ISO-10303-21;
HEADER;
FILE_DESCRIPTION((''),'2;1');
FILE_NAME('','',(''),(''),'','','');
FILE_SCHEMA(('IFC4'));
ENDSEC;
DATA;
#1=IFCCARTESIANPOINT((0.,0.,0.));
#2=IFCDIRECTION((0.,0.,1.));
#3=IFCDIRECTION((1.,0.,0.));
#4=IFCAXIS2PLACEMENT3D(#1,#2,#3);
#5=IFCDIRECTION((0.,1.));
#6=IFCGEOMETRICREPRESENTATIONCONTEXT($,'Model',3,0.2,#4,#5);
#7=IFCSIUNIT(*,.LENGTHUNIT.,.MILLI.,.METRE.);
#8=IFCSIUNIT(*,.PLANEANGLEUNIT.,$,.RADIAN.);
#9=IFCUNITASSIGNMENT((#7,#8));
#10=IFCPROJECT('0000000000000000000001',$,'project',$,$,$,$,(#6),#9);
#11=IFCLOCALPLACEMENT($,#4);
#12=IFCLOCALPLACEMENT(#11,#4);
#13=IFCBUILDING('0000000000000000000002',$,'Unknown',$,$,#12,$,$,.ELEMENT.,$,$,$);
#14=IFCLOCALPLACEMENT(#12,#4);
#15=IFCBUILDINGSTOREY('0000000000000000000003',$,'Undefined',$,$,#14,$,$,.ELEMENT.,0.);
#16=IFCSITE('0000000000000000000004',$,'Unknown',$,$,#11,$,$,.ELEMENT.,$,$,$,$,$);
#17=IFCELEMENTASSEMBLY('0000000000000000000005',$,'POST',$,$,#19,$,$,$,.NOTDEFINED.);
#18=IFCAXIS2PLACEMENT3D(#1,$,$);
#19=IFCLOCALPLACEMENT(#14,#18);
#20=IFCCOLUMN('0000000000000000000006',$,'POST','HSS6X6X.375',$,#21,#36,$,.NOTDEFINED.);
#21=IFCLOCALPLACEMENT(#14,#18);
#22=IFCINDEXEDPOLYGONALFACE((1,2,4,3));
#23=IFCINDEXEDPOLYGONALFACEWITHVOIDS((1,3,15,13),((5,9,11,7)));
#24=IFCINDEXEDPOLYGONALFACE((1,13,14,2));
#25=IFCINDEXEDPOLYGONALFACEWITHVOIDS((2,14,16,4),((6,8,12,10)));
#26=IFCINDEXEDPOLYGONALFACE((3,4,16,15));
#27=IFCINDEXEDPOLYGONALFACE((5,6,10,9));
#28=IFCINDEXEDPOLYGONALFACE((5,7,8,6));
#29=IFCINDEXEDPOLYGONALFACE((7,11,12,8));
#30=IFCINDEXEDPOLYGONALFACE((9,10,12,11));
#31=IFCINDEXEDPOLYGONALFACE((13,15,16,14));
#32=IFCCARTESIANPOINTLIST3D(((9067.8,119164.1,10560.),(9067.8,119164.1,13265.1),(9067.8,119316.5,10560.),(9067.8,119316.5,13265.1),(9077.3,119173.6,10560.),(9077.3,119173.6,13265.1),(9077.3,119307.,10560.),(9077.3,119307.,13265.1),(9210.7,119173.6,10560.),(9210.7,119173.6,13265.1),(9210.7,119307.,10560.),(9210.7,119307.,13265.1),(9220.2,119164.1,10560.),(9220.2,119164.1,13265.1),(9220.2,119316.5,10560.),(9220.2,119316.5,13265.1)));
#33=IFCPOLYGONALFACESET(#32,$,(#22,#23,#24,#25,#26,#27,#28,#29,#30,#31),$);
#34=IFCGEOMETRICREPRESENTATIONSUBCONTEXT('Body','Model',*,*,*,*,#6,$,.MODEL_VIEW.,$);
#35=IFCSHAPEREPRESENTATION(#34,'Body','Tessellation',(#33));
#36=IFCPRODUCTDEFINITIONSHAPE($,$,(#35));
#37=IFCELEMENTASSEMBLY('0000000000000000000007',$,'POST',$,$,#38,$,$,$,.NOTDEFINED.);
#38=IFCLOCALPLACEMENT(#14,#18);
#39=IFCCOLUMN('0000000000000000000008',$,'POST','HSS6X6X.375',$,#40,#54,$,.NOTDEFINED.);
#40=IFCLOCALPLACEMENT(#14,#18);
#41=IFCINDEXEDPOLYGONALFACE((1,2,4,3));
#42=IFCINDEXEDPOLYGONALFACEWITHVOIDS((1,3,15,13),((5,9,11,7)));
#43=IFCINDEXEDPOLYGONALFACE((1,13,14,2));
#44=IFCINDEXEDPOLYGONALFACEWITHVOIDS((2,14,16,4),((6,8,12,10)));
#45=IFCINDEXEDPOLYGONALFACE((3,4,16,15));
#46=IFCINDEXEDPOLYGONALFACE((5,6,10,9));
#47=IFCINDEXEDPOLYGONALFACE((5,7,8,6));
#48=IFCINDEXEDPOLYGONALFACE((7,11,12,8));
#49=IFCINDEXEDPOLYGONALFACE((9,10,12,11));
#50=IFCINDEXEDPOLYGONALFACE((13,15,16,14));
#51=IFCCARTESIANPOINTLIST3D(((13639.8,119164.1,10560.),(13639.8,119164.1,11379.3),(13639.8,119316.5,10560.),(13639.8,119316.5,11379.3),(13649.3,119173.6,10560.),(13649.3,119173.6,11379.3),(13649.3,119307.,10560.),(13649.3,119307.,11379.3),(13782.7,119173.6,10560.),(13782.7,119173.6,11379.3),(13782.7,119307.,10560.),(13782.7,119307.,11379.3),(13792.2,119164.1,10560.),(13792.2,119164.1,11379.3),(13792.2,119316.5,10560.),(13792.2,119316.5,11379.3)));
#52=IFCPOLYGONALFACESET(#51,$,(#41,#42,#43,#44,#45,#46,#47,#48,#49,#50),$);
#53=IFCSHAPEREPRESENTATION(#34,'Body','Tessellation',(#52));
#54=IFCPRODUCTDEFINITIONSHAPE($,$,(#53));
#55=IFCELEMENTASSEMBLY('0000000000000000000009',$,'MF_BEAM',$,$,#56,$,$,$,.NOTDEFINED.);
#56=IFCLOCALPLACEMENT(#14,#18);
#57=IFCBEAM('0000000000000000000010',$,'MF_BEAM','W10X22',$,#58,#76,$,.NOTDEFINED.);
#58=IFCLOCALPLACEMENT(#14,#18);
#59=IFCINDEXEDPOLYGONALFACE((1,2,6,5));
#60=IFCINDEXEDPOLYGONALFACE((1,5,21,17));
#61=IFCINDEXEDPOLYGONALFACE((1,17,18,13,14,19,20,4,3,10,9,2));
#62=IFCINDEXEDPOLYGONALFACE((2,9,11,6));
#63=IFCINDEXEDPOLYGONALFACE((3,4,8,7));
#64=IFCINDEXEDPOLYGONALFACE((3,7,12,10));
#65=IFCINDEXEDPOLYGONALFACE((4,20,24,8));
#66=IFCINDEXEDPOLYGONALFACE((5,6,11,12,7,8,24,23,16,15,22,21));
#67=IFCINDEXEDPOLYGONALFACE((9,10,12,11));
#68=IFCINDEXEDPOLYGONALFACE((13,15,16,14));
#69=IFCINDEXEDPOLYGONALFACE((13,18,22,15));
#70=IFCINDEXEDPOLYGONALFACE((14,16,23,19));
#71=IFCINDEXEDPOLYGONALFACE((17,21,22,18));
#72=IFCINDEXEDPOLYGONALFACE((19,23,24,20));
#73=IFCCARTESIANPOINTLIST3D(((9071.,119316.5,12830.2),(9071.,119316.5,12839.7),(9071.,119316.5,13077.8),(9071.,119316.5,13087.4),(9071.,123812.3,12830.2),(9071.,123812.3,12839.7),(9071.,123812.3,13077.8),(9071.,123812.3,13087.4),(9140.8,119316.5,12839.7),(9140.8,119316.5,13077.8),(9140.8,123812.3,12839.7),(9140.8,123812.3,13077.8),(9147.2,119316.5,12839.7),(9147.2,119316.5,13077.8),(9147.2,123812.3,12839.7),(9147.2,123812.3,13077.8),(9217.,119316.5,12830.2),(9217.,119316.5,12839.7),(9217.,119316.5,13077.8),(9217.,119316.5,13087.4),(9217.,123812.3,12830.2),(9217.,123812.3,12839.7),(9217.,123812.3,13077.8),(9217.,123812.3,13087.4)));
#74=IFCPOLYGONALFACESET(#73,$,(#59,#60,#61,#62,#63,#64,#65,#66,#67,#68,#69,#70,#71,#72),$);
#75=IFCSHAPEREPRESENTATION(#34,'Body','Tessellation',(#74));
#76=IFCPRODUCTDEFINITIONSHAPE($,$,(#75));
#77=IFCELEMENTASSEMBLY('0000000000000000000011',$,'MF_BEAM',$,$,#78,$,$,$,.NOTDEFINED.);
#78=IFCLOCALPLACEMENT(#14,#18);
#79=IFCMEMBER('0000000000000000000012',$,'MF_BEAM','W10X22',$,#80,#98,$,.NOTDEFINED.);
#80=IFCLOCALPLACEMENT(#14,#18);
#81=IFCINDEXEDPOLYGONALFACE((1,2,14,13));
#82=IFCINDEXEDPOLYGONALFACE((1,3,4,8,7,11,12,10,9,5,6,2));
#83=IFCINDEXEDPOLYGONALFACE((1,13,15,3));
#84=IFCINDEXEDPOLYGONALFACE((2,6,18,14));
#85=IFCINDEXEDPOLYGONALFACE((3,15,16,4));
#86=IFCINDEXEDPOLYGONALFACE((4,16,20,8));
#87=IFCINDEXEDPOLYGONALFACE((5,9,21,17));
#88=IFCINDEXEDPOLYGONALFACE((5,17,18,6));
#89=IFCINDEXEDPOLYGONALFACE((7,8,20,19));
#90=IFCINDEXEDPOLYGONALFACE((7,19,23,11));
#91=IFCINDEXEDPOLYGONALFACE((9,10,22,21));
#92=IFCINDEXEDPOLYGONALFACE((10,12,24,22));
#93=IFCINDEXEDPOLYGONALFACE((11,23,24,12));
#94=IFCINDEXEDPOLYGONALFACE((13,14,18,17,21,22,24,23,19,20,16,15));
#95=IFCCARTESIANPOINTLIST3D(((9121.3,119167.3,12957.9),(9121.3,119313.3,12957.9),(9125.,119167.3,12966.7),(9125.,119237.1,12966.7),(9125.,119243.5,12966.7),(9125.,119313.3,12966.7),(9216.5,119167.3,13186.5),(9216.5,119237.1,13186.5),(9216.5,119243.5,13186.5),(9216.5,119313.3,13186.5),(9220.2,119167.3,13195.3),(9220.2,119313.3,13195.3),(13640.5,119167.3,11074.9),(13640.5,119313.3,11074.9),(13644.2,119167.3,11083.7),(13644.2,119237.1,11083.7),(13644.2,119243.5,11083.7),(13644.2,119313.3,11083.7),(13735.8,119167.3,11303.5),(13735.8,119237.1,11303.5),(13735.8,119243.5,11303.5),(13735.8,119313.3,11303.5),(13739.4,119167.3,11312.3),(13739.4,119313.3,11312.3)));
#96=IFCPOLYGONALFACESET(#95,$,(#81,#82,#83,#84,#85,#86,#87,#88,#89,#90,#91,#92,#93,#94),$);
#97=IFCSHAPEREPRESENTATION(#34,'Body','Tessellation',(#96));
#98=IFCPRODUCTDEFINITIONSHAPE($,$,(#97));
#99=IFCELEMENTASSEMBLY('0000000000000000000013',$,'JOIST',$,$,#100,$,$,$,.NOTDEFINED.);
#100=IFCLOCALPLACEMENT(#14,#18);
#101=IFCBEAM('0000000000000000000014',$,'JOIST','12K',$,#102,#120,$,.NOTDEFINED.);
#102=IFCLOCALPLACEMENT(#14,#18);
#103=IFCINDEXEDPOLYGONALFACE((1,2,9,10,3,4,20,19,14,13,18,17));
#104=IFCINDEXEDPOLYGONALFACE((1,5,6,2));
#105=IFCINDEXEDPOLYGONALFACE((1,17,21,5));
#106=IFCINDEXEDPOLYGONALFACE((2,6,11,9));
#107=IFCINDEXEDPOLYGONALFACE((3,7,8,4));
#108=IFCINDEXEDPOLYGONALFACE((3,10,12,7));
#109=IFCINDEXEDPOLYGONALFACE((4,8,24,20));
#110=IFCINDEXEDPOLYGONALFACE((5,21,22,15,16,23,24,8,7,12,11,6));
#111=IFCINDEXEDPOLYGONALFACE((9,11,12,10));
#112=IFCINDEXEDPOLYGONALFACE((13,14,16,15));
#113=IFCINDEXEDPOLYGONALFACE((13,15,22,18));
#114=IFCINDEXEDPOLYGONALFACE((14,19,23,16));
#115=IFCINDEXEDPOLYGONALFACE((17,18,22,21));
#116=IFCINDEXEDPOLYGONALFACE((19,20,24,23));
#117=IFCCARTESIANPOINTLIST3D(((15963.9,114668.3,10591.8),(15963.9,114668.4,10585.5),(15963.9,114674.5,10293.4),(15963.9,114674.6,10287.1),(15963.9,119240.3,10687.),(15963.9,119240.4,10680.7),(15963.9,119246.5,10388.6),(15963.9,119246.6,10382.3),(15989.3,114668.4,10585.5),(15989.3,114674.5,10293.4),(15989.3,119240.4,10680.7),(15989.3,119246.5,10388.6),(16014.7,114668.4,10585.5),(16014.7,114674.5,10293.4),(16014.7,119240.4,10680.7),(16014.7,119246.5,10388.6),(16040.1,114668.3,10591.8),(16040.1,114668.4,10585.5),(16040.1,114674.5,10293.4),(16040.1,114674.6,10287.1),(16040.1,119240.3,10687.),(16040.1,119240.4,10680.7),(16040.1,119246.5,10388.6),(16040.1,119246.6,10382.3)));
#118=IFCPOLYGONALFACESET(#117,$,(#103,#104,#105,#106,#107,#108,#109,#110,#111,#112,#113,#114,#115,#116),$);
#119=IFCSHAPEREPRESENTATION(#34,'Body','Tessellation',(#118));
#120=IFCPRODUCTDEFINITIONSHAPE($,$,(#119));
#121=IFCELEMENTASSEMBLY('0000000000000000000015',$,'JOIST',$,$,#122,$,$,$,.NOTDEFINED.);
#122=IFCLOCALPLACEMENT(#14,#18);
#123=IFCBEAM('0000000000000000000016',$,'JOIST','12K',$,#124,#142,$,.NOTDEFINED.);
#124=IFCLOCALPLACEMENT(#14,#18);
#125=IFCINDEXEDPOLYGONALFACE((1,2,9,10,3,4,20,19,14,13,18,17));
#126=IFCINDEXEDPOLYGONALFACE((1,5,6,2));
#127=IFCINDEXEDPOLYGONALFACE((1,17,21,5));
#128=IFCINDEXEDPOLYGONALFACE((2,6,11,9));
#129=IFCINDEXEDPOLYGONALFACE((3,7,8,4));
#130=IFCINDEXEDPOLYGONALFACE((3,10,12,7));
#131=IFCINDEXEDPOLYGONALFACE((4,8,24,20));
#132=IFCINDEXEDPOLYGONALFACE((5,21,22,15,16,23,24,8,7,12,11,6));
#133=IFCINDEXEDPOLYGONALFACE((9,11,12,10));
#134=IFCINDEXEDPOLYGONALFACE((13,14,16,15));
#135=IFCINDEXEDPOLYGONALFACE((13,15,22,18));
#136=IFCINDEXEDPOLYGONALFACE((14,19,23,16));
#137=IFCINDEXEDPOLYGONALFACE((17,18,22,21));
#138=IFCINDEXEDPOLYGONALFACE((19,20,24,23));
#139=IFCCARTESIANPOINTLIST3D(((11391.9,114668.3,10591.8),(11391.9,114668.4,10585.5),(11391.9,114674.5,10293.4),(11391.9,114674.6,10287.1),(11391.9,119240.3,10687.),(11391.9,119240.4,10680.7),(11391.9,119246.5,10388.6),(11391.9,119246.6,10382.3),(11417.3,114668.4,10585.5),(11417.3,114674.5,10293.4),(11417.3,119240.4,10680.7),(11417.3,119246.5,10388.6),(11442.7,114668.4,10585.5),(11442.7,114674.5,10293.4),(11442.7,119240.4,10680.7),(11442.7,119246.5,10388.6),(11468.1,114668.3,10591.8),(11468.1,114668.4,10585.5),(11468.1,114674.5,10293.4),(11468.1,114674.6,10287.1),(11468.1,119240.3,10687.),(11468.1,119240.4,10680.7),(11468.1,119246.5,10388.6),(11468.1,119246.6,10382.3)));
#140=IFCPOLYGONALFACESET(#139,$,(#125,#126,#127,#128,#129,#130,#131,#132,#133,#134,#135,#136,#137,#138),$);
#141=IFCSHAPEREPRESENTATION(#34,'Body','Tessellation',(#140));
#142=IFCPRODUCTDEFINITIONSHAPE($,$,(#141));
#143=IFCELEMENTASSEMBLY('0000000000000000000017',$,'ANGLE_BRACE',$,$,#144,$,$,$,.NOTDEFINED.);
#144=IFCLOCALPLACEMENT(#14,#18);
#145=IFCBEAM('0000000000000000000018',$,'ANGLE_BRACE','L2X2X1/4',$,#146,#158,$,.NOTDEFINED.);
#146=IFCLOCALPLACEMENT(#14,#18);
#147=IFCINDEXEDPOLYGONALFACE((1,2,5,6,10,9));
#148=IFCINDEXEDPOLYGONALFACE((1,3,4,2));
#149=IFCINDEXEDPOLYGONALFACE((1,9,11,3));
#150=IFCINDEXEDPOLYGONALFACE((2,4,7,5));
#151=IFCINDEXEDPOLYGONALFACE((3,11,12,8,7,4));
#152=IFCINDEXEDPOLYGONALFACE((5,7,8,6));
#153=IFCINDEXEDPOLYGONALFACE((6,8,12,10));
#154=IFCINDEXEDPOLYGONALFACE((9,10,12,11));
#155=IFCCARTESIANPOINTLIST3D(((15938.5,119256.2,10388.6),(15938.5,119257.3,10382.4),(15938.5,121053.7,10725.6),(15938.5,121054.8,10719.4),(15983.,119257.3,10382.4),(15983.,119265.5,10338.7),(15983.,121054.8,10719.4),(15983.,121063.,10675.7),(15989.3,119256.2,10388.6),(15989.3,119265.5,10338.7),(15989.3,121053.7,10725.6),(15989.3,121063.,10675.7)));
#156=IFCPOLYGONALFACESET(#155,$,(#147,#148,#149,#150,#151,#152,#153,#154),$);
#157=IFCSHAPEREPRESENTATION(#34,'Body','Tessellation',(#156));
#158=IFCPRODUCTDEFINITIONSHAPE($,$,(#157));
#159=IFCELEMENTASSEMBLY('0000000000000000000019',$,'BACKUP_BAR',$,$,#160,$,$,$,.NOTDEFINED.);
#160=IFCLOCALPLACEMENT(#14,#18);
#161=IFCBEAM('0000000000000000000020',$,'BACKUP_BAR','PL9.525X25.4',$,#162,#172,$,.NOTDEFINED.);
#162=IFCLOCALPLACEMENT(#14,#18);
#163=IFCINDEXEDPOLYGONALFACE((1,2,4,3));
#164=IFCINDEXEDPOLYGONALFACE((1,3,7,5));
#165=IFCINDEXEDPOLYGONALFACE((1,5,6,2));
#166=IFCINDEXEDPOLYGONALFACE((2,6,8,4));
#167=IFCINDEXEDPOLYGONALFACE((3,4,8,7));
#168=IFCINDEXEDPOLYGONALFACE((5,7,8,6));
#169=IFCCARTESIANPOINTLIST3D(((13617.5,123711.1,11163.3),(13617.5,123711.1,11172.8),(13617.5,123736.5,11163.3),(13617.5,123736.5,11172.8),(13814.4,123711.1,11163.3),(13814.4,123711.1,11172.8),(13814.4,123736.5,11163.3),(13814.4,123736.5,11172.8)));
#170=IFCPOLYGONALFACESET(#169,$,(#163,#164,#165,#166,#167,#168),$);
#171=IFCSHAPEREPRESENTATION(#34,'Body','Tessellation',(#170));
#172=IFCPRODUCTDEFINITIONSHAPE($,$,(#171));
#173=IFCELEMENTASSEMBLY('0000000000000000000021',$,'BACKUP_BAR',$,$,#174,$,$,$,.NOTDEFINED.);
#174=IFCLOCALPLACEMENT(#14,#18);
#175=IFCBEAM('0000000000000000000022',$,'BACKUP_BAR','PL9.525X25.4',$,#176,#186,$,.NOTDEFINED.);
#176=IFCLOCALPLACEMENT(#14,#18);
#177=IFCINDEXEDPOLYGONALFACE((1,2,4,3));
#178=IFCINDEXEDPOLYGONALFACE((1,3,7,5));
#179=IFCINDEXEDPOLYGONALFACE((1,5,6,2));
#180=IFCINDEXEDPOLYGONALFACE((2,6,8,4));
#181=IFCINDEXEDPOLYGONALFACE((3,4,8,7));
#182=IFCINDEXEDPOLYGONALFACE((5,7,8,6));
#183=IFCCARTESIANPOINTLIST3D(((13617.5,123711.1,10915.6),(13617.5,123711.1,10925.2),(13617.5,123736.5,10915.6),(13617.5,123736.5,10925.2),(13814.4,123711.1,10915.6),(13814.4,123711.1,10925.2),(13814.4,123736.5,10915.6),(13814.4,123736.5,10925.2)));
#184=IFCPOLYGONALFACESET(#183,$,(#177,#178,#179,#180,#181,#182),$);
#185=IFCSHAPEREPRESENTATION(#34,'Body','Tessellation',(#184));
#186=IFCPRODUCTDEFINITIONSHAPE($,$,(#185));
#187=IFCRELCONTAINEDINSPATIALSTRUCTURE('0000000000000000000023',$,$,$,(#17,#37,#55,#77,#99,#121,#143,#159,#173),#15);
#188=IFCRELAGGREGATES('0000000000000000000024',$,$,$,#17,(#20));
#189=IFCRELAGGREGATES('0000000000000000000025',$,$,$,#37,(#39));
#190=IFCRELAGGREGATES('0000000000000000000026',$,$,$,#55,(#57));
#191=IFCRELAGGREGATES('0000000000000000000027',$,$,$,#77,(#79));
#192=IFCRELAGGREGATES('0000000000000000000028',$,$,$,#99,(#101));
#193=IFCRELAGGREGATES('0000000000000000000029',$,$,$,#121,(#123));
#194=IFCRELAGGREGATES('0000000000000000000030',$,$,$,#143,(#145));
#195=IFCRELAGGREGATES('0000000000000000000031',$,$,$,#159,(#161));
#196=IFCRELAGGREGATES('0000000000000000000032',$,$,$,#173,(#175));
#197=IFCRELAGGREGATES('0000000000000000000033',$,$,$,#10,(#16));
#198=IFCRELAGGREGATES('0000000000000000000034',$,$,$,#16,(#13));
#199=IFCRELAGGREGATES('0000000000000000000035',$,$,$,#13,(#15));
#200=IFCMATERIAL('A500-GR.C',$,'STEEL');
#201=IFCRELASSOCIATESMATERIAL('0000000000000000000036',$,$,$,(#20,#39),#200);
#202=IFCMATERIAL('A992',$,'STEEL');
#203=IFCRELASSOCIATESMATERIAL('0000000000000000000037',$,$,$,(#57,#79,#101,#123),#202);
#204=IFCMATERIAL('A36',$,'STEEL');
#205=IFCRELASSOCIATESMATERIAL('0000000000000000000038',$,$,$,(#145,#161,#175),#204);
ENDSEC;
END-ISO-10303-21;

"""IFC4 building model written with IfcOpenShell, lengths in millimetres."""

from ifc_helpers import new_model, si_unit, direction, frame, origin_with_axes, place, context, subcontext, project, spatial, line, indexed_curve, outline, extrude, material, element, aggregate, save


model = new_model("IFC4")

# Units and contexts
model_context = context("Model", 3, precision=0.2, world=origin_with_axes(), true_north=direction((0.0, 1.0)))
body_context = subcontext(model_context, "Body", "Model", "MODEL_VIEW")
ifc_project = project(units=[si_unit("LENGTHUNIT", "METRE", prefix="MILLI"), si_unit("PLANEANGLEUNIT", "RADIAN")], contexts=[model_context])

# Site, building, storey
site_placement = place(None, origin_with_axes())
site = spatial("IfcSite", under=ifc_project, at=site_placement, Name="Unknown", CompositionType="ELEMENT")
building_placement = place(site_placement, origin_with_axes())
building = spatial("IfcBuilding", under=site, at=building_placement, Name="Unknown", CompositionType="ELEMENT")
storey_placement = place(building_placement, origin_with_axes())
storey = spatial("IfcBuildingStorey", under=building, at=storey_placement, Name="Undefined", CompositionType="ELEMENT", Elevation=0.0)

# Element assemblies, columns
assembly_1_placement = place(storey_placement, frame((9144.0, 119240.3, 10560.0), z_axis=(0.0, -1.0, 0.0), x_axis=(0.0, 0.0, 1.0)))
assembly_1 = element("IfcElementAssembly", 1, at=assembly_1_placement, inside=storey, Name="POST", PredefinedType="NOTDEFINED")
ifc_material_1 = material(Name="A500-GR.C", Category="STEEL")
column_1_placement = place(assembly_1_placement, origin_with_axes())
column_1 = element("IfcColumn", 2, at=column_1_placement, material=ifc_material_1, Name="POST", Description="HSS6X6X.375", PredefinedType="NOTDEFINED", context=body_context, shape_type="SolidModel", body=[
    extrude(outline(indexed_curve([(-76.2, -76.2), (76.2, -76.2), (76.2, 76.2), (-76.2, 76.2)], segments=[line(1, 2, 3, 4, 1)]), holes=[indexed_curve([(-66.7, -66.7), (-66.7, 66.7), (66.7, 66.7), (66.7, -66.7)], segments=[line(1, 2, 3, 4, 1)])]), frame((0.0, 0.0, 0.0), z_axis=(-1.0, 0.0, 0.0), x_axis=(0.0, 0.0, 1.0)), (0.0, 0.0, -1.0), 2705.1),
])
aggregate(assembly_1, [column_1])
assembly_2_placement = place(storey_placement, frame((13716.0, 119240.3, 10560.0), z_axis=(0.0, -1.0, 0.0), x_axis=(0.0, 0.0, 1.0)))
assembly_2 = element("IfcElementAssembly", 3, at=assembly_2_placement, inside=storey, Name="POST", PredefinedType="NOTDEFINED")
column_2_placement = place(assembly_2_placement, origin_with_axes())
column_2 = element("IfcColumn", 4, at=column_2_placement, material=ifc_material_1, Name="POST", Description="HSS6X6X.375", PredefinedType="NOTDEFINED", context=body_context, shape_type="SolidModel", body=[
    extrude(outline(indexed_curve([(-76.2, -76.2), (76.2, -76.2), (76.2, 76.2), (-76.2, 76.2)], segments=[line(1, 2, 3, 4, 1)]), holes=[indexed_curve([(-66.7, -66.7), (-66.7, 66.7), (66.7, 66.7), (66.7, -66.7)], segments=[line(1, 2, 3, 4, 1)])]), frame((0.0, 0.0, 0.0), z_axis=(-1.0, 0.0, 0.0), x_axis=(0.0, 0.0, 1.0)), (0.0, 0.0, -1.0), 819.2),
])
aggregate(assembly_2, [column_2])

# Element assembly, beam
assembly_3_placement = place(storey_placement, frame((9144.0, 119316.5, 12958.8), z_axis=(1.0, 0.0, 0.0), x_axis=(0.0, 1.0, 0.0)))
assembly_3 = element("IfcElementAssembly", 5, at=assembly_3_placement, inside=storey, Name="MF_BEAM", PredefinedType="NOTDEFINED")
ifc_material_2 = material(Name="A992", Category="STEEL")
beam_1_placement = place(assembly_3_placement, origin_with_axes())
beam_1 = element("IfcBeam", 6, at=beam_1_placement, material=ifc_material_2, Name="MF_BEAM", Description="W10X22", PredefinedType="NOTDEFINED", context=body_context, shape_type="SolidModel", body=[
    extrude(outline(indexed_curve([(-73.0, -128.6), (73.0, -128.6), (73.0, -119.1), (3.2, -119.1), (3.2, 119.1), (73.0, 119.1), (73.0, 128.6), (-73.0, 128.6), (-73.0, 119.1), (-3.2, 119.1), (-3.2, -119.1), (-73.0, -119.1)], segments=[line(1, 2, 3, 4, 5, 6, 7, 8, 9, 10, 11, 12, 1)])), frame((0.0, 0.0, 0.0), z_axis=(-1.0, 0.0, 0.0), x_axis=(0.0, 0.0, 1.0)), (0.0, 0.0, -1.0), 4495.8),
])
aggregate(assembly_3, [beam_1])

# Element assembly, member
assembly_4_placement = place(storey_placement, frame((9170.7, 119240.3, 13076.6), z_axis=(0.0, -1.0, 0.0), x_axis=(0.923077, 0.000001, -0.384615)))
assembly_4 = element("IfcElementAssembly", 7, at=assembly_4_placement, inside=storey, Name="MF_BEAM", PredefinedType="NOTDEFINED")
member_1_placement = place(assembly_4_placement, origin_with_axes())
member_1 = element("IfcMember", 8, at=member_1_placement, material=ifc_material_2, Name="MF_BEAM", Description="W10X22", PredefinedType="NOTDEFINED", context=body_context, shape_type="SolidModel", body=[
    extrude(outline(indexed_curve([(-73.0, -128.6), (73.0, -128.6), (73.0, -119.1), (3.2, -119.1), (3.2, 119.1), (73.0, 119.1), (73.0, 128.6), (-73.0, 128.6), (-73.0, 119.1), (-3.2, 119.1), (-3.2, -119.1), (-73.0, -119.1)], segments=[line(1, 2, 3, 4, 5, 6, 7, 8, 9, 10, 11, 12, 1)])), frame((0.0, 0.0, 0.0), z_axis=(-1.0, 0.0, 0.0), x_axis=(0.0, 0.0, 1.0)), (0.0, 0.0, -1.0), 4895.8),
])
aggregate(assembly_4, [member_1])

# Element assemblies, beams
assembly_5_placement = place(storey_placement, frame((16002.0, 114671.5, 10439.4), z_axis=(1.0, 0.0, 0.0), x_axis=(0.0, 0.999783, 0.020819)))
assembly_5 = element("IfcElementAssembly", 9, at=assembly_5_placement, inside=storey, Name="JOIST", PredefinedType="NOTDEFINED")
beam_2_placement = place(assembly_5_placement, origin_with_axes())
beam_2 = element("IfcBeam", 10, at=beam_2_placement, material=ifc_material_2, Name="JOIST", Description="12K", PredefinedType="NOTDEFINED", context=body_context, shape_type="SolidModel", body=[
    extrude(outline(indexed_curve([(-38.1, -152.4), (38.1, -152.4), (38.1, -146.0), (12.7, -146.0), (12.7, 146.0), (38.1, 146.0), (38.1, 152.4), (-38.1, 152.4), (-38.1, 146.0), (-12.7, 146.0), (-12.7, -146.0), (-38.1, -146.0)], segments=[line(1, 2, 3, 4, 5, 6, 7, 8, 9, 10, 11, 12, 1)])), frame((0.0, 0.0, 0.0), z_axis=(-1.0, 0.0, 0.0), x_axis=(0.0, 0.0, 1.0)), (0.0, 0.0, -1.0), 4573.0),
])
aggregate(assembly_5, [beam_2])
assembly_6_placement = place(storey_placement, frame((11430.0, 114671.5, 10439.4), z_axis=(1.0, 0.0, 0.0), x_axis=(0.0, 0.999783, 0.020819)))
assembly_6 = element("IfcElementAssembly", 11, at=assembly_6_placement, inside=storey, Name="JOIST", PredefinedType="NOTDEFINED")
beam_3_placement = place(assembly_6_placement, origin_with_axes())
beam_3 = element("IfcBeam", 12, at=beam_3_placement, material=ifc_material_2, Name="JOIST", Description="12K", PredefinedType="NOTDEFINED", context=body_context, shape_type="SolidModel", body=[
    extrude(outline(indexed_curve([(-38.1, -152.4), (38.1, -152.4), (38.1, -146.0), (12.7, -146.0), (12.7, 146.0), (38.1, 146.0), (38.1, 152.4), (-38.1, 152.4), (-38.1, 146.0), (-12.7, 146.0), (-12.7, -146.0), (-38.1, -146.0)], segments=[line(1, 2, 3, 4, 5, 6, 7, 8, 9, 10, 11, 12, 1)])), frame((0.0, 0.0, 0.0), z_axis=(-1.0, 0.0, 0.0), x_axis=(0.0, 0.0, 1.0)), (0.0, 0.0, -1.0), 4573.0),
])
aggregate(assembly_6, [beam_3])
assembly_7_placement = place(storey_placement, frame((15963.9, 121058.3, 10700.7), z_axis=(0.0, 0.184286, -0.982873), x_axis=(0.0, -0.982873, -0.184286)))
assembly_7 = element("IfcElementAssembly", 13, at=assembly_7_placement, inside=storey, Name="ANGLE_BRACE", PredefinedType="NOTDEFINED")
ifc_material_3 = material(Name="A36", Category="STEEL")
beam_4_placement = place(assembly_7_placement, origin_with_axes())
beam_4 = element("IfcBeam", 14, at=beam_4_placement, material=ifc_material_3, Name="ANGLE_BRACE", Description="L2X2X1/4", PredefinedType="NOTDEFINED", context=body_context, shape_type="SolidModel", body=[
    extrude(outline(indexed_curve([(-25.4, -25.4), (25.4, -25.4), (25.4, -19.1), (-19.1, -19.1), (-19.1, 25.4), (-25.4, 25.4)], segments=[line(1, 2, 3, 4, 5, 6, 1)])), frame((0.0, 0.0, 0.0), z_axis=(-1.0, 0.0, 0.0), x_axis=(0.0, 0.0, 1.0)), (0.0, 0.0, -1.0), 1828.8),
])
aggregate(assembly_7, [beam_4])
assembly_8_placement = place(storey_placement, frame((13617.5, 123723.8, 11168.1), z_axis=(0.0, 0.0, 1.0), x_axis=(1.0, 0.0, 0.0)))
assembly_8 = element("IfcElementAssembly", 15, at=assembly_8_placement, inside=storey, Name="BACKUP_BAR", PredefinedType="NOTDEFINED")
beam_5_placement = place(assembly_8_placement, origin_with_axes())
beam_5 = element("IfcBeam", 16, at=beam_5_placement, material=ifc_material_3, Name="BACKUP_BAR", Description="PL9.525X25.4", PredefinedType="NOTDEFINED", context=body_context, shape_type="SolidModel", body=[
    extrude(outline(indexed_curve([(-4.8, -12.7), (4.8, -12.7), (4.8, 12.7), (-4.8, 12.7)], segments=[line(1, 2, 3, 4, 1)])), frame((0.0, 0.0, 0.0), z_axis=(-1.0, 0.0, 0.0), x_axis=(0.0, 0.0, 1.0)), (0.0, 0.0, -1.0), 196.8),
])
aggregate(assembly_8, [beam_5])
assembly_9_placement = place(storey_placement, frame((13617.5, 123723.8, 10920.4), z_axis=(0.0, 0.0, 1.0), x_axis=(1.0, 0.0, 0.0)))
assembly_9 = element("IfcElementAssembly", 17, at=assembly_9_placement, inside=storey, Name="BACKUP_BAR", PredefinedType="NOTDEFINED")
beam_6_placement = place(assembly_9_placement, origin_with_axes())
beam_6 = element("IfcBeam", 18, at=beam_6_placement, material=ifc_material_3, Name="BACKUP_BAR", Description="PL9.525X25.4", PredefinedType="NOTDEFINED", context=body_context, shape_type="SolidModel", body=[
    extrude(outline(indexed_curve([(-4.8, -12.7), (4.8, -12.7), (4.8, 12.7), (-4.8, 12.7)], segments=[line(1, 2, 3, 4, 1)])), frame((0.0, 0.0, 0.0), z_axis=(-1.0, 0.0, 0.0), x_axis=(0.0, 0.0, 1.0)), (0.0, 0.0, -1.0), 196.8),
])
aggregate(assembly_9, [beam_6])

save(model, "model.ifc")
